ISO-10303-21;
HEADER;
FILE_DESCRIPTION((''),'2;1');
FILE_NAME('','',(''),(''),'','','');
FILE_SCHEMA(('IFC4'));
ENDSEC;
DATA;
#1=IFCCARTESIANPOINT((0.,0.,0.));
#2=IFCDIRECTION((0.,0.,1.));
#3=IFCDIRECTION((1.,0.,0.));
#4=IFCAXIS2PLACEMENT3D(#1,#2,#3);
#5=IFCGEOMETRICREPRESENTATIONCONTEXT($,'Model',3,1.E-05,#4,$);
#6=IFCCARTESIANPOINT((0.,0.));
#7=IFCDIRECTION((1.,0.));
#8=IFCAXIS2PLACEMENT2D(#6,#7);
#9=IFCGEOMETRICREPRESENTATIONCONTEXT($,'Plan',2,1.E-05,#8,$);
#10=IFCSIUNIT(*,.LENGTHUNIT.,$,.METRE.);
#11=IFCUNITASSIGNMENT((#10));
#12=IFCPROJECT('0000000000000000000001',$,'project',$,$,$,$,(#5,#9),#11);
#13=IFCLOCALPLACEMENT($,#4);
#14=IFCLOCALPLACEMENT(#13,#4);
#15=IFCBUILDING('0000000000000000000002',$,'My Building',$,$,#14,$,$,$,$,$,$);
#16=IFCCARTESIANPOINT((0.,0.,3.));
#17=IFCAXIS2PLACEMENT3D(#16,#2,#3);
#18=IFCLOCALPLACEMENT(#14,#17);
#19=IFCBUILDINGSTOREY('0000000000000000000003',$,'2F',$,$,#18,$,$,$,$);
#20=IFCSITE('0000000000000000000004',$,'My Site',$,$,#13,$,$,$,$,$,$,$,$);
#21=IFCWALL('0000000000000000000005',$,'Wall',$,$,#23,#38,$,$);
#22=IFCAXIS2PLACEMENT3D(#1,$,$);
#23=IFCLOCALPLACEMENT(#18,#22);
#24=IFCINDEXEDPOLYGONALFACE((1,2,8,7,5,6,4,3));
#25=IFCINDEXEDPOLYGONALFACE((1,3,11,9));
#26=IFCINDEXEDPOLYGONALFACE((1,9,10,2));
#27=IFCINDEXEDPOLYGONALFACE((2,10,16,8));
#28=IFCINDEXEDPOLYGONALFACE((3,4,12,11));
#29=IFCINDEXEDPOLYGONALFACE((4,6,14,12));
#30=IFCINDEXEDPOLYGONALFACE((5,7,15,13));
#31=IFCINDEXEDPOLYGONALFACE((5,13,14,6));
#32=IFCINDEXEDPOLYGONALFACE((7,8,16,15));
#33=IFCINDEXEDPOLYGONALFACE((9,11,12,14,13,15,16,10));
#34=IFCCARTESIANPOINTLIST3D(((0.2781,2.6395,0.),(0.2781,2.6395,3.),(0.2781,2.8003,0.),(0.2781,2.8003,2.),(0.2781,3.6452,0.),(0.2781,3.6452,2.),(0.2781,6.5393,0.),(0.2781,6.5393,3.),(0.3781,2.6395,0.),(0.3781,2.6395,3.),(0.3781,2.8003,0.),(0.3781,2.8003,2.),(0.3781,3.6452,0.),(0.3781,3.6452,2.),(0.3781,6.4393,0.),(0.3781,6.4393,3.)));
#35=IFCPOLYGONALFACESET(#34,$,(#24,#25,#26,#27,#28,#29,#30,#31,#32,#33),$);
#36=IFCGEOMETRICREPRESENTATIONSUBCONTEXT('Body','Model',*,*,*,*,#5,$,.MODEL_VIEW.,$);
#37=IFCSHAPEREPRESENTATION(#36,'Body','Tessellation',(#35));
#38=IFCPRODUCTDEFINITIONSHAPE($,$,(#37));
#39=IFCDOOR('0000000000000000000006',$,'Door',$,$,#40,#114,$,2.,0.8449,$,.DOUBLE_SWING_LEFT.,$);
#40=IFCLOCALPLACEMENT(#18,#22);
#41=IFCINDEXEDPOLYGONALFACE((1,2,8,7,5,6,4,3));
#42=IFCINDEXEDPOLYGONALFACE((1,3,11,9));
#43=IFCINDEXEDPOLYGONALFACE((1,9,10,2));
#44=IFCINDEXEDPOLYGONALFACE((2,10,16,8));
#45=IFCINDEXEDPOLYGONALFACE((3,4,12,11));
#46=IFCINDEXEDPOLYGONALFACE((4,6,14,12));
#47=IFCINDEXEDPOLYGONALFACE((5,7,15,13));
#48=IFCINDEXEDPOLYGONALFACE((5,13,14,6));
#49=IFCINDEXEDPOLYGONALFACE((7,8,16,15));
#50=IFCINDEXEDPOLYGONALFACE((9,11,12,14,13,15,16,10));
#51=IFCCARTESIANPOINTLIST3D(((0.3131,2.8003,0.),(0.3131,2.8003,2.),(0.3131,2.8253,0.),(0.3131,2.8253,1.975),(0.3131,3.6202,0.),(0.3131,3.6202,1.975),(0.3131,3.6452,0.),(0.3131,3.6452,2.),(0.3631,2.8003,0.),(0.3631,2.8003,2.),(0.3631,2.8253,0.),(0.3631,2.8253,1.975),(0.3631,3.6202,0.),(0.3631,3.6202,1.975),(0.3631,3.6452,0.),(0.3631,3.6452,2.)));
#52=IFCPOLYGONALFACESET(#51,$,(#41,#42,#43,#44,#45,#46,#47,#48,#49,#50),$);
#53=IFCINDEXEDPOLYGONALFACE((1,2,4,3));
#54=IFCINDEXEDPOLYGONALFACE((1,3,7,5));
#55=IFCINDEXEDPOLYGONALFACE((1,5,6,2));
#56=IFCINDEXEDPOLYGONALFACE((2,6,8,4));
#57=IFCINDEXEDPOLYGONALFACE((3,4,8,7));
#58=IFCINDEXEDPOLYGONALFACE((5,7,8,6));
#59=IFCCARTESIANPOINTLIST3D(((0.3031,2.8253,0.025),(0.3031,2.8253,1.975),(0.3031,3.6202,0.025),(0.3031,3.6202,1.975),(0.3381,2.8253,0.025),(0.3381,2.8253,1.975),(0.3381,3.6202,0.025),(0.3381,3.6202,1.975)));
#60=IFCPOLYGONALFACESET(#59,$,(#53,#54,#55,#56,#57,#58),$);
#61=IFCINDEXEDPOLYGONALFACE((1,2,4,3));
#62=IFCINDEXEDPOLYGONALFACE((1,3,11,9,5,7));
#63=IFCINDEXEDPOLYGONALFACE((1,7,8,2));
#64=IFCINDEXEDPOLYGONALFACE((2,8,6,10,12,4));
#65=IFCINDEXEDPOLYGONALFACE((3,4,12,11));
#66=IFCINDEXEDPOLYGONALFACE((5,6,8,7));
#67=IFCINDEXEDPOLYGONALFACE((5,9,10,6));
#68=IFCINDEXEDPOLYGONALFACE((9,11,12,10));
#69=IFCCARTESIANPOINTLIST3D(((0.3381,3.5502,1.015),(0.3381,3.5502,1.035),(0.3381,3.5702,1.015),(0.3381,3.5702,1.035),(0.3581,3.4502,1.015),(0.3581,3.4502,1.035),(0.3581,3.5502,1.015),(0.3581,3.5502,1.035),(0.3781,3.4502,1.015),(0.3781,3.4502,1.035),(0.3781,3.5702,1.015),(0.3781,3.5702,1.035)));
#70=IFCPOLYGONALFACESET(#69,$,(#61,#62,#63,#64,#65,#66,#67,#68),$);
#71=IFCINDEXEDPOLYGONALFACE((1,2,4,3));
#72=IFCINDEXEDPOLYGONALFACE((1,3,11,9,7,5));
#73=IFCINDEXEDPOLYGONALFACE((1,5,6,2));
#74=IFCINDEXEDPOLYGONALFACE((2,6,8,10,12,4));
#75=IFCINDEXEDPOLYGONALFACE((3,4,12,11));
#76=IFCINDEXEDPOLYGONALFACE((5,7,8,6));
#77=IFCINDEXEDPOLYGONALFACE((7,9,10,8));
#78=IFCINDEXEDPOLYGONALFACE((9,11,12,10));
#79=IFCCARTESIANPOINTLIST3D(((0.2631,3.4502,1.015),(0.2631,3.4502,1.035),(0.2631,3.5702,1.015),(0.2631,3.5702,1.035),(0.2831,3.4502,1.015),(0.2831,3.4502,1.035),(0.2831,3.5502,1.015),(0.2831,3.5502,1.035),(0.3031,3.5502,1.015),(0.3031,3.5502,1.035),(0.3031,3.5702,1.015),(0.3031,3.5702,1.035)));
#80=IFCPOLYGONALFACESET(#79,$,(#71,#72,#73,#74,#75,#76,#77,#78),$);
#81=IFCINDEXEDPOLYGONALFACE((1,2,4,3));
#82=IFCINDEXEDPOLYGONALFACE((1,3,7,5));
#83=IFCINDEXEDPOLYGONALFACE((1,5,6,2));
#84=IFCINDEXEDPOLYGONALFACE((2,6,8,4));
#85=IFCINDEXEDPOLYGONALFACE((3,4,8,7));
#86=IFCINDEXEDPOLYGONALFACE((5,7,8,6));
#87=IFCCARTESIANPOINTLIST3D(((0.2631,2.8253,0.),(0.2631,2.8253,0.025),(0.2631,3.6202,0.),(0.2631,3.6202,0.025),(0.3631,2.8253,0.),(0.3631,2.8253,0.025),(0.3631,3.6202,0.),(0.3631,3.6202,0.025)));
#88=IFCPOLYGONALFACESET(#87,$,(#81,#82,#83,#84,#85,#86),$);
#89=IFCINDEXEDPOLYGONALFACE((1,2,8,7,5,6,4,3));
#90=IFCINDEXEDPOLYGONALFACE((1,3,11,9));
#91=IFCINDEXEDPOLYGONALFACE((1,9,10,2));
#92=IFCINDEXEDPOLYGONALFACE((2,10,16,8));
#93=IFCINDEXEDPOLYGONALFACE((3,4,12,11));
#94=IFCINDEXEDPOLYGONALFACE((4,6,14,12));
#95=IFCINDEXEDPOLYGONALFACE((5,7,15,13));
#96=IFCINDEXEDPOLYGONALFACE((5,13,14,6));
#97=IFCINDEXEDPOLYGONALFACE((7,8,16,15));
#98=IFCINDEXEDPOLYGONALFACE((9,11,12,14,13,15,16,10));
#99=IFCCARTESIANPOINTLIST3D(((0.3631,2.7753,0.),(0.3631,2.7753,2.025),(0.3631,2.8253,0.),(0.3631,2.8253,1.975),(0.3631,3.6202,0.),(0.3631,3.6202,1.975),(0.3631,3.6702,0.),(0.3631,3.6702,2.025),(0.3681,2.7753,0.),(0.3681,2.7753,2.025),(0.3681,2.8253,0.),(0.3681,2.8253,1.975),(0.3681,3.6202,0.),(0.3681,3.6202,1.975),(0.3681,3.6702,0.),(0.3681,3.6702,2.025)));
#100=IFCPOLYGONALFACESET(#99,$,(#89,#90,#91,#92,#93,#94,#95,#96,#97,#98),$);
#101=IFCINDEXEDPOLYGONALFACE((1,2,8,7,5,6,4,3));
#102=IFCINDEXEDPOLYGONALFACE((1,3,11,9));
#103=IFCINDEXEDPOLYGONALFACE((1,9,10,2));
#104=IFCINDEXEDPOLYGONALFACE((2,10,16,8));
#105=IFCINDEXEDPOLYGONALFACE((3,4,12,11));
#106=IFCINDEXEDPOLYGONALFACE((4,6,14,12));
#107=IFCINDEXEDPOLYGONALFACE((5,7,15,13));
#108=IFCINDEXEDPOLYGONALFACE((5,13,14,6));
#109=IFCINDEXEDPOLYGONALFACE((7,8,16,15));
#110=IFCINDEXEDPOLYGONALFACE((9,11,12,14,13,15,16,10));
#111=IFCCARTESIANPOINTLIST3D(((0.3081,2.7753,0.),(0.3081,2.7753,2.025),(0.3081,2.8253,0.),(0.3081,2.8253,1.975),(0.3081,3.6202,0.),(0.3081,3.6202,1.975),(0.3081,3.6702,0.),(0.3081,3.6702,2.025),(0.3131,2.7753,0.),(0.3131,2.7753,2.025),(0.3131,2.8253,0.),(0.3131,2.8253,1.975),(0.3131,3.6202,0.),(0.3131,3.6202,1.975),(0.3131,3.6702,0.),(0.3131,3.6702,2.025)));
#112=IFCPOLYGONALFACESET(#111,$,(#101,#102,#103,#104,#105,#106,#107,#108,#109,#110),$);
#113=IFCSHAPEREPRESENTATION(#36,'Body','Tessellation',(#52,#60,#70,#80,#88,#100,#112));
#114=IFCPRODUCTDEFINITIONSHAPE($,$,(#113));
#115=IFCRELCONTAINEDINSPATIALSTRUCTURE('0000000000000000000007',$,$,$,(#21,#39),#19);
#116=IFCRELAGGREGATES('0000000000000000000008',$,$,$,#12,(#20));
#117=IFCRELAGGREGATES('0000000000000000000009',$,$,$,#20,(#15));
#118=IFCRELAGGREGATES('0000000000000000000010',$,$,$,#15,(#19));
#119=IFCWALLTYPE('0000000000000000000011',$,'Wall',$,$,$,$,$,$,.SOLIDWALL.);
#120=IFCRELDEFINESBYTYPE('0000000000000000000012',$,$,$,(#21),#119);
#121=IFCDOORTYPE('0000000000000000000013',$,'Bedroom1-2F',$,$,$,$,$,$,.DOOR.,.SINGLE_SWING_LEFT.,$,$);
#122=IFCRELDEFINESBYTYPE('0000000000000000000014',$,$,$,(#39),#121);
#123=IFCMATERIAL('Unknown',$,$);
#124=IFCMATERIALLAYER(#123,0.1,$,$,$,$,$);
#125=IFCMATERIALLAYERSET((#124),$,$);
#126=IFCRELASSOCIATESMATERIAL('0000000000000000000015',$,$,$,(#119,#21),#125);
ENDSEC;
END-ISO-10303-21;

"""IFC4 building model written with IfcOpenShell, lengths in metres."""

from ifc_helpers import new_model, entity, si_unit, frame, origin_with_axes, origin_2d_with_axis, place, context, subcontext, project, spatial, line, indexed_curve, outline, extrude, shape, source, transform, mapped, material, layer, layer_set, layer_usage, type_object, type_shapes, element, fill, save


model = new_model("IFC4")

# Units and contexts
model_context = context("Model", 3, precision=1e-05, world=origin_with_axes())
plan_context = context("Plan", 2, precision=1e-05, world=origin_2d_with_axis())
body_context_1 = subcontext(model_context, "Body", "Model", "MODEL_VIEW")
body_context_2 = subcontext(plan_context, "Body", "Plan", "PLAN_VIEW")
ifc_project = project(units=[si_unit("LENGTHUNIT", "METRE")], contexts=[model_context, plan_context])

# Site, building, storey
site_placement = place(None, origin_with_axes())
site = spatial("IfcSite", under=ifc_project, at=site_placement, Name="My Site")
building_placement = place(site_placement, origin_with_axes())
building = spatial("IfcBuilding", under=site, at=building_placement, Name="My Building")
storey_placement = place(building_placement, frame((0.0, 0.0, 3.0), z_axis=(0.0, 0.0, 1.0), x_axis=(1.0, 0.0, 0.0)))
storey = spatial("IfcBuildingStorey", under=building, at=storey_placement, Name="2F")

# Shared definitions
ifc_material = material(Name="Unknown")

# Shared definitions
ifc_layer_1 = layer(ifc_material, 0.1)
ifc_layer_set_1 = layer_set([ifc_layer_1])
wall_type = type_object("IfcWallType", Name="Wall", PredefinedType="SOLIDWALL", material=ifc_layer_set_1)

# Wall, opening, door
ifc_layer_usage_1 = layer_usage(ifc_layer_set_1, "AXIS2", "POSITIVE", 0.0)
wall_1_placement = place(storey_placement, frame((0.2781, 6.5393, 0.0), z_axis=(0.0, 0.0, 1.0), x_axis=(0.0, -1.0, 0.0)))
wall_1 = element("IfcWall", 1, at=wall_1_placement, inside=storey, type_object=wall_type, material=ifc_layer_usage_1, Name="Wall", context=body_context_1, shape_type="SweptSolid", body=[
    extrude(outline(indexed_curve([(0.0, 0.0), (0.1, 0.1), (3.8998, 0.1), (3.8998, 0.0)], segments=[line(1, 2, 3, 4, 1)])), origin_with_axes(), (0.0, 0.0, 1.0), 3.0),
])
shared_shape_1 = source(origin_with_axes(), body_context_1, "Body", "SweptSolid", [
    extrude(outline(indexed_curve([(0.0, 0.0), (0.8449, 0.0), (0.8449, 2.0), (0.0, 2.0)], segments=[line(1, 2, 3, 4, 1)])), frame((0.0, -0.6, 0.0), z_axis=(0.0, -1.0, 0.0), x_axis=(1.0, 0.0, 0.0)), (0.0, 0.0, -1.0), 1.2),
])
opening_1_placement = place(wall_1_placement, frame((3.739, 0.085, 0.0), z_axis=(0.0, 0.0, 1.0), x_axis=(-1.0, 0.0, 0.0)))
opening_1 = element("IfcOpeningElement", 2, at=opening_1_placement, cuts=wall_1, PredefinedType="OPENING", context=body_context_1, shape_type="MappedRepresentation", body=[
    mapped(shared_shape_1, transform((0.0, 0.0, 0.0), x_axis=(1.0, 0.0, 0.0), y_axis=(0.0, 1.0, 0.0), z_axis=(0.0, 0.0, 1.0), scale=1.0)),
])
door_type_1 = type_object("IfcDoorType", Name="Bedroom1-2F", OperationType="SINGLE_SWING_LEFT", PredefinedType="DOOR")
shared_shape_2 = source(origin_with_axes(), body_context_1, "Body", "SweptSolid", [
    extrude(outline(indexed_curve([(0.0, 0.0), (0.0, 2.0), (0.8449, 2.0), (0.8449, 0.0), (0.8199, 0.0), (0.8199, 1.975), (0.025, 1.975), (0.025, 0.0)], segments=[line(1, 2, 3, 4, 5, 6, 7, 8, 1)])), frame((0.0, 0.0, 0.0), z_axis=(0.0, -1.0, 0.0), x_axis=(1.0, 0.0, 0.0)), (0.0, 0.0, -1.0), 0.05),
    extrude(outline(indexed_curve([(0.0, 0.0), (0.7949, 0.0), (0.7949, 0.035), (0.0, 0.035)], segments=[line(1, 2, 3, 4, 1)])), frame((0.025, 0.025, 0.025), z_axis=(0.0, 0.0, 1.0), x_axis=(1.0, 0.0, 0.0)), (0.0, 0.0, 1.0), 1.95),
    extrude(outline(indexed_curve([(0.0, 0.0), (0.0, -0.04), (-0.12, -0.04), (-0.12, -0.02), (-0.02, -0.02), (-0.02, 0.0)], segments=[line(1, 2, 3, 4, 5, 6, 1)])), frame((0.7699, 0.025, 1.015), z_axis=(0.0, 0.0, 1.0), x_axis=(1.0, 0.0, 0.0)), (0.0, 0.0, 1.0), 0.02),
    extrude(outline(indexed_curve([(0.0, 0.0), (0.0, 0.04), (-0.12, 0.04), (-0.12, 0.02), (-0.02, 0.02), (-0.02, 0.0)], segments=[line(1, 2, 3, 4, 5, 6, 1)])), frame((0.7699, 0.06, 1.015), z_axis=(0.0, 0.0, 1.0), x_axis=(1.0, 0.0, 0.0)), (0.0, 0.0, 1.0), 0.02),
    extrude(outline(indexed_curve([(0.0, 0.0), (0.7949, 0.0), (0.7949, 0.1), (0.0, 0.1)], segments=[line(1, 2, 3, 4, 1)])), frame((0.025, 0.0, 0.0), z_axis=(0.0, 0.0, 1.0), x_axis=(1.0, 0.0, 0.0)), (0.0, 0.0, 1.0), 0.025),
    extrude(outline(indexed_curve([(0.0, 0.0), (0.0, 2.025), (0.8949, 2.025), (0.8949, 0.0), (0.8449, 0.0), (0.8449, 1.975), (0.05, 1.975), (0.05, 0.0)], segments=[line(1, 2, 3, 4, 5, 6, 7, 8, 1)])), frame((-0.025, -0.005, 0.0), z_axis=(0.0, -1.0, 0.0), x_axis=(1.0, 0.0, 0.0)), (0.0, 0.0, -1.0), 0.005),
    extrude(outline(indexed_curve([(0.0, 0.0), (0.0, 2.025), (0.8949, 2.025), (0.8949, 0.0), (0.8449, 0.0), (0.8449, 1.975), (0.05, 1.975), (0.05, 0.0)], segments=[line(1, 2, 3, 4, 5, 6, 7, 8, 1)])), frame((-0.025, 0.05, 0.0), z_axis=(0.0, -1.0, 0.0), x_axis=(1.0, 0.0, 0.0)), (0.0, 0.0, -1.0), 0.005),
])
shared_shape_3 = source(origin_with_axes(), body_context_2, "Body", "Curve2D", [
    entity("IfcIndexedPolyCurve", entity("IfcCartesianPointList2D", [[0.0, 0.0], [0.025, 0.0], [0.025, 0.05], [0.0, 0.05]]), [entity("IfcLineIndex", [1, 2, 3, 4, 1])]),
    entity("IfcIndexedPolyCurve", entity("IfcCartesianPointList2D", [[0.8449, 0.0], [0.8199, 0.0], [0.8199, 0.05], [0.8449, 0.05]]), [entity("IfcLineIndex", [1, 2, 3, 4, 1])]),
    entity("IfcIndexedPolyCurve", entity("IfcCartesianPointList2D", [[0.025, 0.05], [0.025, -0.7449], [0.06, -0.7449]])),
    entity("IfcTrimmedCurve", entity("IfcEllipse", entity("IfcAxis2Placement2D", entity("IfcCartesianPoint", [0.06, 0.05]), entity("IfcDirection", [1.0, 0.0])), 0.7599, 0.7949), [entity("IfcCartesianPoint", [0.06, -0.7449])], [entity("IfcCartesianPoint", [0.06, 0.8449])], True, "CARTESIAN"),
    entity("IfcIndexedPolyCurve", entity("IfcCartesianPointList2D", [[0.025, 0.05], [0.06, 0.05], [0.06, 0.8449], [0.025, 0.8449]]), [entity("IfcLineIndex", [1, 2, 3, 4, 1])]),
])
type_shapes(door_type_1, [shared_shape_2, shared_shape_3])
door_1_placement = place(opening_1_placement, frame((0.0, 0.0, 0.0), z_axis=(0.0, 0.0, 1.0), x_axis=(1.0, 0.0, 0.0)))
door_1 = element("IfcDoor", 3, at=door_1_placement, inside=storey, type_object=door_type_1, Name="Door", OperationType="DOUBLE_SWING_LEFT", OverallHeight=2.0, OverallWidth=0.8449, shapes=[
    shape(body_context_1, "Body", "MappedRepresentation", [mapped(shared_shape_2, transform((0.0, 0.0, 0.0), x_axis=(1.0, 0.0, 0.0), y_axis=(0.0, 1.0, 0.0), z_axis=(0.0, 0.0, 1.0), scale=1.0))]),
    shape(body_context_2, "Body", "MappedRepresentation", [mapped(shared_shape_3, transform((0.0, 0.0, 0.0), x_axis=(1.0, 0.0, 0.0), y_axis=(0.0, 1.0, 0.0), z_axis=(0.0, 0.0, 1.0), scale=1.0))]),
])
fill(opening_1, door_1)

save(model, "model.ifc")
